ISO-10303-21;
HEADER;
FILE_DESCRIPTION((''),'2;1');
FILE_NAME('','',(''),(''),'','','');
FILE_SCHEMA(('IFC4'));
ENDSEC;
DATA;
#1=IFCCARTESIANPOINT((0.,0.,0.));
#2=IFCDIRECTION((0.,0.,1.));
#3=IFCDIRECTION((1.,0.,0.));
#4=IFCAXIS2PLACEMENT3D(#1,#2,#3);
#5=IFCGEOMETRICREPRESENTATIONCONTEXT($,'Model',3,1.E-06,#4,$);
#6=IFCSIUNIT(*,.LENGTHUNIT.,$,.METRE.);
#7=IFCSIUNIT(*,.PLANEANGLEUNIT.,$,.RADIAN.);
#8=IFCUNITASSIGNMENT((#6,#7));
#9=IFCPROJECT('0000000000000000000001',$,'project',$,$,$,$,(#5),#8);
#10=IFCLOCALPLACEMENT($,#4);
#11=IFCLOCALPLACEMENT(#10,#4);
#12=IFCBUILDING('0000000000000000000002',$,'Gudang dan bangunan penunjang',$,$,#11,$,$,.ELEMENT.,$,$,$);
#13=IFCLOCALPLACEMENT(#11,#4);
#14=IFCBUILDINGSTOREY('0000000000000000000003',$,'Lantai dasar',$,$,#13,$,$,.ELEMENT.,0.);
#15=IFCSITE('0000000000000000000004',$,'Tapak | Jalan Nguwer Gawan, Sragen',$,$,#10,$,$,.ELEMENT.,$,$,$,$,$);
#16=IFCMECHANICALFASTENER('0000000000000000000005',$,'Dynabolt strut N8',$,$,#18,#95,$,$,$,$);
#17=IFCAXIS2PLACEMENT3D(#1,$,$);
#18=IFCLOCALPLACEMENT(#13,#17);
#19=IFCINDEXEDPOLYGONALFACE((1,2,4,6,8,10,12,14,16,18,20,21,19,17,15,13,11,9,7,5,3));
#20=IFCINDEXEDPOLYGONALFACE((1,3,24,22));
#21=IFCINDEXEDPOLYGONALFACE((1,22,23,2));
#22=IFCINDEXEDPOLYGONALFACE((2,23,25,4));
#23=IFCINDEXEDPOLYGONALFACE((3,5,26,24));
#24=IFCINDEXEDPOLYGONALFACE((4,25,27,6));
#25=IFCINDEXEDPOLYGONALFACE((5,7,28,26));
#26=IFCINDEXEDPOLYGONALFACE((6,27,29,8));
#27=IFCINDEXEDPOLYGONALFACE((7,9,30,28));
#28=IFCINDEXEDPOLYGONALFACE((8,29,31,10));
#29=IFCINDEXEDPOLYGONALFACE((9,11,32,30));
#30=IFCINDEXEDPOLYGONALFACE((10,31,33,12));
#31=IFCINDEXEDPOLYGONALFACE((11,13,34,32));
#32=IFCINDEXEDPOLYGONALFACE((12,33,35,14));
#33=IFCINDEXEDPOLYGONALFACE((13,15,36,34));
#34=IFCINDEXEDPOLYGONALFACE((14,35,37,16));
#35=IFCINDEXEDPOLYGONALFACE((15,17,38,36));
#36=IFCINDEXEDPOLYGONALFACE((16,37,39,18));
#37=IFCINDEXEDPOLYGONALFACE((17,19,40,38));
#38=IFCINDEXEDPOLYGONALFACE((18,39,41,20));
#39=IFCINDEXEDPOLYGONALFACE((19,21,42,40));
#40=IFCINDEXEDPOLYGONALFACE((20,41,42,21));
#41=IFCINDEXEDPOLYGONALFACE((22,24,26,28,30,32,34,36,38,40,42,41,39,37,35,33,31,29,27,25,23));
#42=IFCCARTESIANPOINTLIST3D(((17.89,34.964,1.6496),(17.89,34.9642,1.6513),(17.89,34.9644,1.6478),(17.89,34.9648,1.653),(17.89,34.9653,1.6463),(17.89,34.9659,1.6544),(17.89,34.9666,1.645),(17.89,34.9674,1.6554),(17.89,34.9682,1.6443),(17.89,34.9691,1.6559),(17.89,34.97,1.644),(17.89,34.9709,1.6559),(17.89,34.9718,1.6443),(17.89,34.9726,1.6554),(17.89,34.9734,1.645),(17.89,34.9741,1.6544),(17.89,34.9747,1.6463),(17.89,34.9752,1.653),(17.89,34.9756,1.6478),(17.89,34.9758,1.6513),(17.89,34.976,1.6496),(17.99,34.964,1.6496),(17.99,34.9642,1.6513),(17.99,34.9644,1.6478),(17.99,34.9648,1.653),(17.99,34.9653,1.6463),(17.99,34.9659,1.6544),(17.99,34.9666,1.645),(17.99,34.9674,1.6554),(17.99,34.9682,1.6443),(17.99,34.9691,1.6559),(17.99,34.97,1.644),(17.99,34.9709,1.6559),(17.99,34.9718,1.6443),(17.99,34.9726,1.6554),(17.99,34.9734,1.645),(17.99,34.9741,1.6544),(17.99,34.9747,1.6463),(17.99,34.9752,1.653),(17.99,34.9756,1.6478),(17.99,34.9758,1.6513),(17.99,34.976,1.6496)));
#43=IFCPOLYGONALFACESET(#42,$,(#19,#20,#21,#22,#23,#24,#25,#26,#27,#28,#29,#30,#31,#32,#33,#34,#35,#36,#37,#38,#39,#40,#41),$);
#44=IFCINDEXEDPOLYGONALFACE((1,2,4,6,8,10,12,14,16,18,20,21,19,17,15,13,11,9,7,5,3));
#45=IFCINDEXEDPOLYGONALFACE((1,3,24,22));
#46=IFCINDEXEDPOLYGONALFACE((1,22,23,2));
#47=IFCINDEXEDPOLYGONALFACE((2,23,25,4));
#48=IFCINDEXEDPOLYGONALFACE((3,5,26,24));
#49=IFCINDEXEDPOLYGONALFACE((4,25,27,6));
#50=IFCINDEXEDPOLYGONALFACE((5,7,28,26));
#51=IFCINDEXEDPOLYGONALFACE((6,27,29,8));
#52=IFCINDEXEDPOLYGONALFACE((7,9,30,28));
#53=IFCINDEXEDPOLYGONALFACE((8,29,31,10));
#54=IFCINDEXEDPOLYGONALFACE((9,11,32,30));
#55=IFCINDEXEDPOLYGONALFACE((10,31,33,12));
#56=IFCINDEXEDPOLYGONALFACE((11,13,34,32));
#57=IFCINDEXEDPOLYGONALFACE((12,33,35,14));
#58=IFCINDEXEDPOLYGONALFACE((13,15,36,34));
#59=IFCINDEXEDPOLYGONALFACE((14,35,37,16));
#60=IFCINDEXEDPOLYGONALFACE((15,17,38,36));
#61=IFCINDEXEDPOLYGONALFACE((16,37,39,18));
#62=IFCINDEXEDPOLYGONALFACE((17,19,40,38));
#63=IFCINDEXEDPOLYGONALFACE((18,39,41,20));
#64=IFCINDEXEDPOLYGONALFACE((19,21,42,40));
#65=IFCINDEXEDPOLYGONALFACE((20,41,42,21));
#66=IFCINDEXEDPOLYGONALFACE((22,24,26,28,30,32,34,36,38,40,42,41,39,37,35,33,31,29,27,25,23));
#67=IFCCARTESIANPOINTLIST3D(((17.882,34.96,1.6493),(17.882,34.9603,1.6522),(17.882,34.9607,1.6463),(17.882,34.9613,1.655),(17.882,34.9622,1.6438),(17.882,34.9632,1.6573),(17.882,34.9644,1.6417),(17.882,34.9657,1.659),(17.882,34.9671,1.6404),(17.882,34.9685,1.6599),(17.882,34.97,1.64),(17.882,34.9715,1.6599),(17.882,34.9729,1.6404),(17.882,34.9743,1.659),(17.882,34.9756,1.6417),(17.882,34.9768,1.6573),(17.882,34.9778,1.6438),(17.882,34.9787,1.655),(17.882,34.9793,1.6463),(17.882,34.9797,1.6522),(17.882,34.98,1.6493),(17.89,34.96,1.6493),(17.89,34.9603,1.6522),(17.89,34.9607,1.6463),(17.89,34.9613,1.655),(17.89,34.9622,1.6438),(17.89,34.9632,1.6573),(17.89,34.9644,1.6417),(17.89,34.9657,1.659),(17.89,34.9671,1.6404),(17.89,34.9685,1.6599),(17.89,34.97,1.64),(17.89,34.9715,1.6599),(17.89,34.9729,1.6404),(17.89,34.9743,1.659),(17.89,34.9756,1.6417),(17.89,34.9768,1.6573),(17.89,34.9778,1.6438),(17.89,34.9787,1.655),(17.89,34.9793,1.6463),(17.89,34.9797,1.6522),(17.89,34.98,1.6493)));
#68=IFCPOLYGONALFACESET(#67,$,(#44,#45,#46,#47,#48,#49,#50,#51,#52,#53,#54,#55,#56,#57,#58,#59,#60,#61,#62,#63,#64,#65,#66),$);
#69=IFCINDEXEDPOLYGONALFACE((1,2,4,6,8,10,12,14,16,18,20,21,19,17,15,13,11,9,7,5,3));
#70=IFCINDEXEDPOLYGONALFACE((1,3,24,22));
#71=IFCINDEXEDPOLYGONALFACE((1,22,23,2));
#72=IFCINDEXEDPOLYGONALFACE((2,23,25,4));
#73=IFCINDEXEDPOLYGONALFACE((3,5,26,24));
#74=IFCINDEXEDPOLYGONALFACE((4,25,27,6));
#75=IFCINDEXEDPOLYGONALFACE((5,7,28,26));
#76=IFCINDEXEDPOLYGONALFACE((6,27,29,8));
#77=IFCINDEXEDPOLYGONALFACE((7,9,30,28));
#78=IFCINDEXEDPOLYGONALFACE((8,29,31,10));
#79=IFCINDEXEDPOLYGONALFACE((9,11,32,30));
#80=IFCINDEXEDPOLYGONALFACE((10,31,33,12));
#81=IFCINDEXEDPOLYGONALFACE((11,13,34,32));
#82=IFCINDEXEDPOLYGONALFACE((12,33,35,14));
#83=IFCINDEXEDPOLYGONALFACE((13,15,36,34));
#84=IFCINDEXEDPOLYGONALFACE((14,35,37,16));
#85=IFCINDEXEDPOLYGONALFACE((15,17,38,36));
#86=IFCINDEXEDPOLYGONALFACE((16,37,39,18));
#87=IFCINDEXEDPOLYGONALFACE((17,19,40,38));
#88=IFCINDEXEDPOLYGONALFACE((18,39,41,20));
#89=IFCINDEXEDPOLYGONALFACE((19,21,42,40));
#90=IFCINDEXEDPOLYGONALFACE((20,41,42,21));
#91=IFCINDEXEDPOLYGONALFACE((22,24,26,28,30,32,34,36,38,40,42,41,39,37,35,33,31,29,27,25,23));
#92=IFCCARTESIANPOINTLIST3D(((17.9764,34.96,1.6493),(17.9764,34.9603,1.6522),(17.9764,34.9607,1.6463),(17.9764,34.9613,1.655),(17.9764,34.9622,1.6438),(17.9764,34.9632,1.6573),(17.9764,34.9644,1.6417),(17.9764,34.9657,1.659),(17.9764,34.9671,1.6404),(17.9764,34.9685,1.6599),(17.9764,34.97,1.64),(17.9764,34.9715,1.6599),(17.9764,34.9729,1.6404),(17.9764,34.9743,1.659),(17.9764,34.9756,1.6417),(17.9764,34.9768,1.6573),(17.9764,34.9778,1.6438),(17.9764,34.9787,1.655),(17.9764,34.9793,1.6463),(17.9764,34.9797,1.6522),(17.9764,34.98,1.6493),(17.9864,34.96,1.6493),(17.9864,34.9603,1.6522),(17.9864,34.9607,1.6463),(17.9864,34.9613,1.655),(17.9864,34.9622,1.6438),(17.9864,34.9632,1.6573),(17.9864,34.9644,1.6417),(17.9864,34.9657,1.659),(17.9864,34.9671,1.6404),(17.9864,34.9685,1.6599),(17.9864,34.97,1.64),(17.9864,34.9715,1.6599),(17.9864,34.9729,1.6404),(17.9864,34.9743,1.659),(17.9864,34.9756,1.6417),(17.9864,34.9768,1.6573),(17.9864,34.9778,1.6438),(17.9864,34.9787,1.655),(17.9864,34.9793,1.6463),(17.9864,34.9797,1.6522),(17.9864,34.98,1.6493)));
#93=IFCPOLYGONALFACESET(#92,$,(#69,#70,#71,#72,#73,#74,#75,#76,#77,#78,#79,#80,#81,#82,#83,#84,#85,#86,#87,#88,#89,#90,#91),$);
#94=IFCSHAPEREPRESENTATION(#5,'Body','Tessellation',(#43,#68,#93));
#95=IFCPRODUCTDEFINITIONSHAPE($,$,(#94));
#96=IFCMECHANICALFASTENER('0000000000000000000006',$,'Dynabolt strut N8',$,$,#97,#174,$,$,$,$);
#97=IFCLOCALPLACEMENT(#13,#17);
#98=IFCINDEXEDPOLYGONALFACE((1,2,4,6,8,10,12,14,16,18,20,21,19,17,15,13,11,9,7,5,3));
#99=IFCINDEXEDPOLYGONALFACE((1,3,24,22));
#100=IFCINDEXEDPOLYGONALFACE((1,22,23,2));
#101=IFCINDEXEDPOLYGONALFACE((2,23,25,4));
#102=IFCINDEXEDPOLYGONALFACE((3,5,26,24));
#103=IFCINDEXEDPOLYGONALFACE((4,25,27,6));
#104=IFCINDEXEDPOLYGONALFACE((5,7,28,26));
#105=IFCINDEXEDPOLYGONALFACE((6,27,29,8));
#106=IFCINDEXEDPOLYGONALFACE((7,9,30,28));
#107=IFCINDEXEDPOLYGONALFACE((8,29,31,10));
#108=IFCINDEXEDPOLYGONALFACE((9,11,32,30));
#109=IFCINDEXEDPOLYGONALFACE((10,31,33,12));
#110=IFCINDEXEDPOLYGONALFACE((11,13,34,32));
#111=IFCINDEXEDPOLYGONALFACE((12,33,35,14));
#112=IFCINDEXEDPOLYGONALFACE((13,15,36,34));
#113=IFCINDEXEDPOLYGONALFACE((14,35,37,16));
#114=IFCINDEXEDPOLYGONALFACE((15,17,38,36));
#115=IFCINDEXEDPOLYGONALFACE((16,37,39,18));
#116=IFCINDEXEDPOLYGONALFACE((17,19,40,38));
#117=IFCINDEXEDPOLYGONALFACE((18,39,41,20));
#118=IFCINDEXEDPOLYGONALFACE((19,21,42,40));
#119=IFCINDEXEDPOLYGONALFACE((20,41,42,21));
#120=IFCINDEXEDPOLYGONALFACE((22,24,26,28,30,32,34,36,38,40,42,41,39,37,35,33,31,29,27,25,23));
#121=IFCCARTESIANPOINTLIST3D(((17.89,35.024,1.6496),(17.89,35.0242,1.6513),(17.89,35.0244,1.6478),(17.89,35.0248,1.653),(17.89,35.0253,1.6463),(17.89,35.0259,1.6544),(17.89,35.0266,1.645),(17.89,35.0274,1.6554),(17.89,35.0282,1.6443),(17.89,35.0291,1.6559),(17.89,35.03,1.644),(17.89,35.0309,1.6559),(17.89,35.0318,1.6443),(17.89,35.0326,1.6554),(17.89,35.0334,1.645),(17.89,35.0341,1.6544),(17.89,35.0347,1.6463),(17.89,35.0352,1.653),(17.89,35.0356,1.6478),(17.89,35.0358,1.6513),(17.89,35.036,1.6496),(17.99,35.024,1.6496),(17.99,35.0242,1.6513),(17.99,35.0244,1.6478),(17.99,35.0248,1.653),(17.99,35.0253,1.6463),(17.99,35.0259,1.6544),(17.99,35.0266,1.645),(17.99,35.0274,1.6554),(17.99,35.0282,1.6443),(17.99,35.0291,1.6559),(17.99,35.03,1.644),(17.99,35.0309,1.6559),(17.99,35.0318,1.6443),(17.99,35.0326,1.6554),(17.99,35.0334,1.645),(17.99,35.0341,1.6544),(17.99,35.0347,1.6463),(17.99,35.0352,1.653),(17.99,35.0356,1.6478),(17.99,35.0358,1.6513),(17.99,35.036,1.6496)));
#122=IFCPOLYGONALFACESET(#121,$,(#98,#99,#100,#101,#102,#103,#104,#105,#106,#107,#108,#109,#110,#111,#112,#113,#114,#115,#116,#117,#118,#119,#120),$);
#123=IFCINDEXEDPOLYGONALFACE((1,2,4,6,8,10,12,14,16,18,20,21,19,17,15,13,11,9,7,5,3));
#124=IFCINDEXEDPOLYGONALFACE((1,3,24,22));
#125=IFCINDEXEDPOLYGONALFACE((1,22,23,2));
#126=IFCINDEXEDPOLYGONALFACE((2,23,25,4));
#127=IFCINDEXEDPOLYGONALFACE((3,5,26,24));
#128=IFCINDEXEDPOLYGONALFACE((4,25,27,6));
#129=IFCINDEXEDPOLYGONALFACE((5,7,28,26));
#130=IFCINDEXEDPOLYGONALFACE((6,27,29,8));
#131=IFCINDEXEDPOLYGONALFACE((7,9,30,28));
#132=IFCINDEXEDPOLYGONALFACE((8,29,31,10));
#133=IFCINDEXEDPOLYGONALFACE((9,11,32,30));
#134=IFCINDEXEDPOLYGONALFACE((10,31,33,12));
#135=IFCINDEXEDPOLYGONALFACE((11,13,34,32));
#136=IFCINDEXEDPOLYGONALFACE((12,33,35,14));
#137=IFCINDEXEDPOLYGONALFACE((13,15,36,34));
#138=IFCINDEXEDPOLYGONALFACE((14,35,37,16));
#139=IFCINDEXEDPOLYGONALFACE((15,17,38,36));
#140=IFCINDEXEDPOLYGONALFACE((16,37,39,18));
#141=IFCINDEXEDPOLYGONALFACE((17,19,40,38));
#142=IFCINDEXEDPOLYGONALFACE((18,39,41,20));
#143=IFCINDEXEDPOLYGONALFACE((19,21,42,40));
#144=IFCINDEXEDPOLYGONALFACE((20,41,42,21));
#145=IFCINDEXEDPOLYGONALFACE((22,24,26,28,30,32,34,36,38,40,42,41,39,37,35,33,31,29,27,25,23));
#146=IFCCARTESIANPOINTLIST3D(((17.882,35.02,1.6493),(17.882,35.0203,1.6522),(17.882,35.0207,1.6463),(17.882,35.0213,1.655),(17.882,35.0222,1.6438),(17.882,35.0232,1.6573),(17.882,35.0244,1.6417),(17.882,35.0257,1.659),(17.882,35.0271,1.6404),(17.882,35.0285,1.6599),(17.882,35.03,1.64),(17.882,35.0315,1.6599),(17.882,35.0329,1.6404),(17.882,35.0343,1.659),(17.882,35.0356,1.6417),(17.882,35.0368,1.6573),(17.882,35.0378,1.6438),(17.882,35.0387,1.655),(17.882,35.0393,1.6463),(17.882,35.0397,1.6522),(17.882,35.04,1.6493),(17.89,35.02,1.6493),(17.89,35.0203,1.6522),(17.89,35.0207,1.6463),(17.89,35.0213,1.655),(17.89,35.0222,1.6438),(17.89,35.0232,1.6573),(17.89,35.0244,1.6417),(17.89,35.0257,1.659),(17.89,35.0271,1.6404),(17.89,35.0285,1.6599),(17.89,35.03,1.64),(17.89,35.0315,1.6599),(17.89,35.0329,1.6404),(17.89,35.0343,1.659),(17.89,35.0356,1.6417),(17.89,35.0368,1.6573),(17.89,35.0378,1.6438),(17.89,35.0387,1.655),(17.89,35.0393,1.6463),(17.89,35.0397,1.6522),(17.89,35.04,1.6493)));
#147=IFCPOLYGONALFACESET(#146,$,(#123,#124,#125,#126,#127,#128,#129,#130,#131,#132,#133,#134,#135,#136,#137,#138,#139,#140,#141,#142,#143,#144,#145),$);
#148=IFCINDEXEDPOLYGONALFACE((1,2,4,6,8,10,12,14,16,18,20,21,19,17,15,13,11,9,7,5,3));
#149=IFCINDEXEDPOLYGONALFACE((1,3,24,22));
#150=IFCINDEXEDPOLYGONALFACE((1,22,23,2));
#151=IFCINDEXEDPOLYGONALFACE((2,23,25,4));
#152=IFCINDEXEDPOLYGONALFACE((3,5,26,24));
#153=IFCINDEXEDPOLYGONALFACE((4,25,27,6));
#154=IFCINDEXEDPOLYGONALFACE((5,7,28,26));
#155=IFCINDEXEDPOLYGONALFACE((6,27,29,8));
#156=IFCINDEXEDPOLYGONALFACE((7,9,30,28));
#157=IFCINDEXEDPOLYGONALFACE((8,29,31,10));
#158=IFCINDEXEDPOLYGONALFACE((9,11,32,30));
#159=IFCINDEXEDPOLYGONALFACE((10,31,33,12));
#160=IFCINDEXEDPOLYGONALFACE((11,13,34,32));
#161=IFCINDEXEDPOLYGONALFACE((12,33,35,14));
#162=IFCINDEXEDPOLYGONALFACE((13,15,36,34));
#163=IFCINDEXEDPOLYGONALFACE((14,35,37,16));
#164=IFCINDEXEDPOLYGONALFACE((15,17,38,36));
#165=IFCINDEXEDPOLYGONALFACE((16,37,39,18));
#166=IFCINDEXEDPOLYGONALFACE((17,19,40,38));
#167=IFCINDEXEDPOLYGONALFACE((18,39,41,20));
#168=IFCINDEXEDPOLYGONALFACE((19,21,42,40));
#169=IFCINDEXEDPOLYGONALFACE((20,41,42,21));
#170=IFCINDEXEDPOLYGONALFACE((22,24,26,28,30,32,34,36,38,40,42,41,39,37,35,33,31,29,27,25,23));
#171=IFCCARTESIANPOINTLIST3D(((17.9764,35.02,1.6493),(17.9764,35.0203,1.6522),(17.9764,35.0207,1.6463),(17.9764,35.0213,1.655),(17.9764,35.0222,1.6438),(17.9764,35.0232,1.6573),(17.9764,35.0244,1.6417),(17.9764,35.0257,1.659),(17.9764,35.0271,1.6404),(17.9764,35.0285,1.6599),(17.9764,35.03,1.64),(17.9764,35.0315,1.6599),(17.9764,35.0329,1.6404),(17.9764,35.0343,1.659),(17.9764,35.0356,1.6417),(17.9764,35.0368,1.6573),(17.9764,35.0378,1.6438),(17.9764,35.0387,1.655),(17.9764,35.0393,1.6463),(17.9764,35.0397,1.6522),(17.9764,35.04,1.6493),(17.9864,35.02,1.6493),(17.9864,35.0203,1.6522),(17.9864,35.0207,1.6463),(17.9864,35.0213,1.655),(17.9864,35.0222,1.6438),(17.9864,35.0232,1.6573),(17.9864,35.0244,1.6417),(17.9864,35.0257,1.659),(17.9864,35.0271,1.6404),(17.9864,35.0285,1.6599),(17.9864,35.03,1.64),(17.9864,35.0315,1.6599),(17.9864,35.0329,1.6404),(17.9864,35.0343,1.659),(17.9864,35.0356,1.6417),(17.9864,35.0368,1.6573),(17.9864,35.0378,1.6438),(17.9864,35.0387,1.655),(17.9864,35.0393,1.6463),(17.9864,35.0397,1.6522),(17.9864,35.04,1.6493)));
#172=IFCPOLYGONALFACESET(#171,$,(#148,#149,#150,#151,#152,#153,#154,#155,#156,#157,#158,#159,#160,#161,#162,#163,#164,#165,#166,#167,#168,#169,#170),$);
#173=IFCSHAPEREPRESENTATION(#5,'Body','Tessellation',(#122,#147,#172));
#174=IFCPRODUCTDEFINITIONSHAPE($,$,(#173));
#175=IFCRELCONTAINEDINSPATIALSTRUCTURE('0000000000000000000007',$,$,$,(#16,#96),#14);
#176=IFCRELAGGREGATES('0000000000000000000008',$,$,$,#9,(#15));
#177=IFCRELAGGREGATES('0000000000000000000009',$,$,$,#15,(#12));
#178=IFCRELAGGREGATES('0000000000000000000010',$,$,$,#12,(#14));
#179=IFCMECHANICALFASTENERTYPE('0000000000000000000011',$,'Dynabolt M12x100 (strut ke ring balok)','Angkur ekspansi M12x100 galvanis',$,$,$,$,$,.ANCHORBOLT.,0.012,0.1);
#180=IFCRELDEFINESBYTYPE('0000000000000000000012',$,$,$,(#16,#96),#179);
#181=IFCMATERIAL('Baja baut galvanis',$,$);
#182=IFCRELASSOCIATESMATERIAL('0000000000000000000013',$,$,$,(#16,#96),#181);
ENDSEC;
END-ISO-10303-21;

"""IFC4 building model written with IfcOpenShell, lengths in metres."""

from ifc_helpers import new_model, si_unit, frame, origin_with_axes, place, context, project, spatial, circle, extrude, source, transform, mapped, material, type_object, type_shapes, element, save


model = new_model("IFC4")

# Units and contexts
model_context = context("Model", 3, precision=1e-06, world=origin_with_axes())
ifc_project = project(units=[si_unit("LENGTHUNIT", "METRE"), si_unit("PLANEANGLEUNIT", "RADIAN")], contexts=[model_context])

# Site, building, storey
site_placement = place(None, origin_with_axes())
site = spatial("IfcSite", under=ifc_project, at=site_placement, Name="Tapak | Jalan Nguwer Gawan, Sragen", CompositionType="ELEMENT")
building_placement = place(site_placement, origin_with_axes())
building = spatial("IfcBuilding", under=site, at=building_placement, Name="Gudang dan bangunan penunjang", CompositionType="ELEMENT")
storey_placement = place(building_placement, origin_with_axes())
storey = spatial("IfcBuildingStorey", under=building, at=storey_placement, Name="Lantai dasar", CompositionType="ELEMENT", Elevation=0.0)

# Mechanical fasteners
ifc_material = material(Name="Baja baut galvanis")
mechanical_fastener_type = type_object("IfcMechanicalFastenerType", Name="Dynabolt M12x100 (strut ke ring balok)", Description="Angkur ekspansi M12x100 galvanis", NominalDiameter=0.012, NominalLength=0.1, PredefinedType="ANCHORBOLT")
shared_shape = source(origin_with_axes(), model_context, "Body", "SweptSolid", [
    extrude(circle(Radius=0.006), origin_with_axes(), (0.0, 0.0, 1.0), 0.1),
    extrude(circle(Radius=0.01), frame((0.0, 0.0, -0.008), z_axis=(0.0, 0.0, 1.0), x_axis=(1.0, 0.0, 0.0)), (0.0, 0.0, 1.0), 0.008),
    extrude(circle(Radius=0.01), frame((0.0, 0.0, 0.0864), z_axis=(0.0, 0.0, 1.0), x_axis=(1.0, 0.0, 0.0)), (0.0, 0.0, 1.0), 0.01),
])
type_shapes(mechanical_fastener_type, [shared_shape])
placement = place(None, origin_with_axes())
element("IfcMechanicalFastener", 1, at=placement, inside=storey, type_object=mechanical_fastener_type, material=ifc_material, Name="Dynabolt strut N8", context=model_context, shape_type="MappedRepresentation", body=[
    mapped(shared_shape, transform((17.89, 34.97, 1.65), x_axis=(0.0, 0.0, -1.0), y_axis=(0.0, 1.0, 0.0), z_axis=(1.0, 0.0, 0.0), scale=1.0)),
])
element("IfcMechanicalFastener", 2, at=placement, inside=storey, type_object=mechanical_fastener_type, material=ifc_material, Name="Dynabolt strut N8", context=model_context, shape_type="MappedRepresentation", body=[
    mapped(shared_shape, transform((17.89, 35.03, 1.65), x_axis=(0.0, 0.0, -1.0), y_axis=(0.0, 1.0, 0.0), z_axis=(1.0, 0.0, 0.0), scale=1.0)),
])

save(model, "model.ifc")
